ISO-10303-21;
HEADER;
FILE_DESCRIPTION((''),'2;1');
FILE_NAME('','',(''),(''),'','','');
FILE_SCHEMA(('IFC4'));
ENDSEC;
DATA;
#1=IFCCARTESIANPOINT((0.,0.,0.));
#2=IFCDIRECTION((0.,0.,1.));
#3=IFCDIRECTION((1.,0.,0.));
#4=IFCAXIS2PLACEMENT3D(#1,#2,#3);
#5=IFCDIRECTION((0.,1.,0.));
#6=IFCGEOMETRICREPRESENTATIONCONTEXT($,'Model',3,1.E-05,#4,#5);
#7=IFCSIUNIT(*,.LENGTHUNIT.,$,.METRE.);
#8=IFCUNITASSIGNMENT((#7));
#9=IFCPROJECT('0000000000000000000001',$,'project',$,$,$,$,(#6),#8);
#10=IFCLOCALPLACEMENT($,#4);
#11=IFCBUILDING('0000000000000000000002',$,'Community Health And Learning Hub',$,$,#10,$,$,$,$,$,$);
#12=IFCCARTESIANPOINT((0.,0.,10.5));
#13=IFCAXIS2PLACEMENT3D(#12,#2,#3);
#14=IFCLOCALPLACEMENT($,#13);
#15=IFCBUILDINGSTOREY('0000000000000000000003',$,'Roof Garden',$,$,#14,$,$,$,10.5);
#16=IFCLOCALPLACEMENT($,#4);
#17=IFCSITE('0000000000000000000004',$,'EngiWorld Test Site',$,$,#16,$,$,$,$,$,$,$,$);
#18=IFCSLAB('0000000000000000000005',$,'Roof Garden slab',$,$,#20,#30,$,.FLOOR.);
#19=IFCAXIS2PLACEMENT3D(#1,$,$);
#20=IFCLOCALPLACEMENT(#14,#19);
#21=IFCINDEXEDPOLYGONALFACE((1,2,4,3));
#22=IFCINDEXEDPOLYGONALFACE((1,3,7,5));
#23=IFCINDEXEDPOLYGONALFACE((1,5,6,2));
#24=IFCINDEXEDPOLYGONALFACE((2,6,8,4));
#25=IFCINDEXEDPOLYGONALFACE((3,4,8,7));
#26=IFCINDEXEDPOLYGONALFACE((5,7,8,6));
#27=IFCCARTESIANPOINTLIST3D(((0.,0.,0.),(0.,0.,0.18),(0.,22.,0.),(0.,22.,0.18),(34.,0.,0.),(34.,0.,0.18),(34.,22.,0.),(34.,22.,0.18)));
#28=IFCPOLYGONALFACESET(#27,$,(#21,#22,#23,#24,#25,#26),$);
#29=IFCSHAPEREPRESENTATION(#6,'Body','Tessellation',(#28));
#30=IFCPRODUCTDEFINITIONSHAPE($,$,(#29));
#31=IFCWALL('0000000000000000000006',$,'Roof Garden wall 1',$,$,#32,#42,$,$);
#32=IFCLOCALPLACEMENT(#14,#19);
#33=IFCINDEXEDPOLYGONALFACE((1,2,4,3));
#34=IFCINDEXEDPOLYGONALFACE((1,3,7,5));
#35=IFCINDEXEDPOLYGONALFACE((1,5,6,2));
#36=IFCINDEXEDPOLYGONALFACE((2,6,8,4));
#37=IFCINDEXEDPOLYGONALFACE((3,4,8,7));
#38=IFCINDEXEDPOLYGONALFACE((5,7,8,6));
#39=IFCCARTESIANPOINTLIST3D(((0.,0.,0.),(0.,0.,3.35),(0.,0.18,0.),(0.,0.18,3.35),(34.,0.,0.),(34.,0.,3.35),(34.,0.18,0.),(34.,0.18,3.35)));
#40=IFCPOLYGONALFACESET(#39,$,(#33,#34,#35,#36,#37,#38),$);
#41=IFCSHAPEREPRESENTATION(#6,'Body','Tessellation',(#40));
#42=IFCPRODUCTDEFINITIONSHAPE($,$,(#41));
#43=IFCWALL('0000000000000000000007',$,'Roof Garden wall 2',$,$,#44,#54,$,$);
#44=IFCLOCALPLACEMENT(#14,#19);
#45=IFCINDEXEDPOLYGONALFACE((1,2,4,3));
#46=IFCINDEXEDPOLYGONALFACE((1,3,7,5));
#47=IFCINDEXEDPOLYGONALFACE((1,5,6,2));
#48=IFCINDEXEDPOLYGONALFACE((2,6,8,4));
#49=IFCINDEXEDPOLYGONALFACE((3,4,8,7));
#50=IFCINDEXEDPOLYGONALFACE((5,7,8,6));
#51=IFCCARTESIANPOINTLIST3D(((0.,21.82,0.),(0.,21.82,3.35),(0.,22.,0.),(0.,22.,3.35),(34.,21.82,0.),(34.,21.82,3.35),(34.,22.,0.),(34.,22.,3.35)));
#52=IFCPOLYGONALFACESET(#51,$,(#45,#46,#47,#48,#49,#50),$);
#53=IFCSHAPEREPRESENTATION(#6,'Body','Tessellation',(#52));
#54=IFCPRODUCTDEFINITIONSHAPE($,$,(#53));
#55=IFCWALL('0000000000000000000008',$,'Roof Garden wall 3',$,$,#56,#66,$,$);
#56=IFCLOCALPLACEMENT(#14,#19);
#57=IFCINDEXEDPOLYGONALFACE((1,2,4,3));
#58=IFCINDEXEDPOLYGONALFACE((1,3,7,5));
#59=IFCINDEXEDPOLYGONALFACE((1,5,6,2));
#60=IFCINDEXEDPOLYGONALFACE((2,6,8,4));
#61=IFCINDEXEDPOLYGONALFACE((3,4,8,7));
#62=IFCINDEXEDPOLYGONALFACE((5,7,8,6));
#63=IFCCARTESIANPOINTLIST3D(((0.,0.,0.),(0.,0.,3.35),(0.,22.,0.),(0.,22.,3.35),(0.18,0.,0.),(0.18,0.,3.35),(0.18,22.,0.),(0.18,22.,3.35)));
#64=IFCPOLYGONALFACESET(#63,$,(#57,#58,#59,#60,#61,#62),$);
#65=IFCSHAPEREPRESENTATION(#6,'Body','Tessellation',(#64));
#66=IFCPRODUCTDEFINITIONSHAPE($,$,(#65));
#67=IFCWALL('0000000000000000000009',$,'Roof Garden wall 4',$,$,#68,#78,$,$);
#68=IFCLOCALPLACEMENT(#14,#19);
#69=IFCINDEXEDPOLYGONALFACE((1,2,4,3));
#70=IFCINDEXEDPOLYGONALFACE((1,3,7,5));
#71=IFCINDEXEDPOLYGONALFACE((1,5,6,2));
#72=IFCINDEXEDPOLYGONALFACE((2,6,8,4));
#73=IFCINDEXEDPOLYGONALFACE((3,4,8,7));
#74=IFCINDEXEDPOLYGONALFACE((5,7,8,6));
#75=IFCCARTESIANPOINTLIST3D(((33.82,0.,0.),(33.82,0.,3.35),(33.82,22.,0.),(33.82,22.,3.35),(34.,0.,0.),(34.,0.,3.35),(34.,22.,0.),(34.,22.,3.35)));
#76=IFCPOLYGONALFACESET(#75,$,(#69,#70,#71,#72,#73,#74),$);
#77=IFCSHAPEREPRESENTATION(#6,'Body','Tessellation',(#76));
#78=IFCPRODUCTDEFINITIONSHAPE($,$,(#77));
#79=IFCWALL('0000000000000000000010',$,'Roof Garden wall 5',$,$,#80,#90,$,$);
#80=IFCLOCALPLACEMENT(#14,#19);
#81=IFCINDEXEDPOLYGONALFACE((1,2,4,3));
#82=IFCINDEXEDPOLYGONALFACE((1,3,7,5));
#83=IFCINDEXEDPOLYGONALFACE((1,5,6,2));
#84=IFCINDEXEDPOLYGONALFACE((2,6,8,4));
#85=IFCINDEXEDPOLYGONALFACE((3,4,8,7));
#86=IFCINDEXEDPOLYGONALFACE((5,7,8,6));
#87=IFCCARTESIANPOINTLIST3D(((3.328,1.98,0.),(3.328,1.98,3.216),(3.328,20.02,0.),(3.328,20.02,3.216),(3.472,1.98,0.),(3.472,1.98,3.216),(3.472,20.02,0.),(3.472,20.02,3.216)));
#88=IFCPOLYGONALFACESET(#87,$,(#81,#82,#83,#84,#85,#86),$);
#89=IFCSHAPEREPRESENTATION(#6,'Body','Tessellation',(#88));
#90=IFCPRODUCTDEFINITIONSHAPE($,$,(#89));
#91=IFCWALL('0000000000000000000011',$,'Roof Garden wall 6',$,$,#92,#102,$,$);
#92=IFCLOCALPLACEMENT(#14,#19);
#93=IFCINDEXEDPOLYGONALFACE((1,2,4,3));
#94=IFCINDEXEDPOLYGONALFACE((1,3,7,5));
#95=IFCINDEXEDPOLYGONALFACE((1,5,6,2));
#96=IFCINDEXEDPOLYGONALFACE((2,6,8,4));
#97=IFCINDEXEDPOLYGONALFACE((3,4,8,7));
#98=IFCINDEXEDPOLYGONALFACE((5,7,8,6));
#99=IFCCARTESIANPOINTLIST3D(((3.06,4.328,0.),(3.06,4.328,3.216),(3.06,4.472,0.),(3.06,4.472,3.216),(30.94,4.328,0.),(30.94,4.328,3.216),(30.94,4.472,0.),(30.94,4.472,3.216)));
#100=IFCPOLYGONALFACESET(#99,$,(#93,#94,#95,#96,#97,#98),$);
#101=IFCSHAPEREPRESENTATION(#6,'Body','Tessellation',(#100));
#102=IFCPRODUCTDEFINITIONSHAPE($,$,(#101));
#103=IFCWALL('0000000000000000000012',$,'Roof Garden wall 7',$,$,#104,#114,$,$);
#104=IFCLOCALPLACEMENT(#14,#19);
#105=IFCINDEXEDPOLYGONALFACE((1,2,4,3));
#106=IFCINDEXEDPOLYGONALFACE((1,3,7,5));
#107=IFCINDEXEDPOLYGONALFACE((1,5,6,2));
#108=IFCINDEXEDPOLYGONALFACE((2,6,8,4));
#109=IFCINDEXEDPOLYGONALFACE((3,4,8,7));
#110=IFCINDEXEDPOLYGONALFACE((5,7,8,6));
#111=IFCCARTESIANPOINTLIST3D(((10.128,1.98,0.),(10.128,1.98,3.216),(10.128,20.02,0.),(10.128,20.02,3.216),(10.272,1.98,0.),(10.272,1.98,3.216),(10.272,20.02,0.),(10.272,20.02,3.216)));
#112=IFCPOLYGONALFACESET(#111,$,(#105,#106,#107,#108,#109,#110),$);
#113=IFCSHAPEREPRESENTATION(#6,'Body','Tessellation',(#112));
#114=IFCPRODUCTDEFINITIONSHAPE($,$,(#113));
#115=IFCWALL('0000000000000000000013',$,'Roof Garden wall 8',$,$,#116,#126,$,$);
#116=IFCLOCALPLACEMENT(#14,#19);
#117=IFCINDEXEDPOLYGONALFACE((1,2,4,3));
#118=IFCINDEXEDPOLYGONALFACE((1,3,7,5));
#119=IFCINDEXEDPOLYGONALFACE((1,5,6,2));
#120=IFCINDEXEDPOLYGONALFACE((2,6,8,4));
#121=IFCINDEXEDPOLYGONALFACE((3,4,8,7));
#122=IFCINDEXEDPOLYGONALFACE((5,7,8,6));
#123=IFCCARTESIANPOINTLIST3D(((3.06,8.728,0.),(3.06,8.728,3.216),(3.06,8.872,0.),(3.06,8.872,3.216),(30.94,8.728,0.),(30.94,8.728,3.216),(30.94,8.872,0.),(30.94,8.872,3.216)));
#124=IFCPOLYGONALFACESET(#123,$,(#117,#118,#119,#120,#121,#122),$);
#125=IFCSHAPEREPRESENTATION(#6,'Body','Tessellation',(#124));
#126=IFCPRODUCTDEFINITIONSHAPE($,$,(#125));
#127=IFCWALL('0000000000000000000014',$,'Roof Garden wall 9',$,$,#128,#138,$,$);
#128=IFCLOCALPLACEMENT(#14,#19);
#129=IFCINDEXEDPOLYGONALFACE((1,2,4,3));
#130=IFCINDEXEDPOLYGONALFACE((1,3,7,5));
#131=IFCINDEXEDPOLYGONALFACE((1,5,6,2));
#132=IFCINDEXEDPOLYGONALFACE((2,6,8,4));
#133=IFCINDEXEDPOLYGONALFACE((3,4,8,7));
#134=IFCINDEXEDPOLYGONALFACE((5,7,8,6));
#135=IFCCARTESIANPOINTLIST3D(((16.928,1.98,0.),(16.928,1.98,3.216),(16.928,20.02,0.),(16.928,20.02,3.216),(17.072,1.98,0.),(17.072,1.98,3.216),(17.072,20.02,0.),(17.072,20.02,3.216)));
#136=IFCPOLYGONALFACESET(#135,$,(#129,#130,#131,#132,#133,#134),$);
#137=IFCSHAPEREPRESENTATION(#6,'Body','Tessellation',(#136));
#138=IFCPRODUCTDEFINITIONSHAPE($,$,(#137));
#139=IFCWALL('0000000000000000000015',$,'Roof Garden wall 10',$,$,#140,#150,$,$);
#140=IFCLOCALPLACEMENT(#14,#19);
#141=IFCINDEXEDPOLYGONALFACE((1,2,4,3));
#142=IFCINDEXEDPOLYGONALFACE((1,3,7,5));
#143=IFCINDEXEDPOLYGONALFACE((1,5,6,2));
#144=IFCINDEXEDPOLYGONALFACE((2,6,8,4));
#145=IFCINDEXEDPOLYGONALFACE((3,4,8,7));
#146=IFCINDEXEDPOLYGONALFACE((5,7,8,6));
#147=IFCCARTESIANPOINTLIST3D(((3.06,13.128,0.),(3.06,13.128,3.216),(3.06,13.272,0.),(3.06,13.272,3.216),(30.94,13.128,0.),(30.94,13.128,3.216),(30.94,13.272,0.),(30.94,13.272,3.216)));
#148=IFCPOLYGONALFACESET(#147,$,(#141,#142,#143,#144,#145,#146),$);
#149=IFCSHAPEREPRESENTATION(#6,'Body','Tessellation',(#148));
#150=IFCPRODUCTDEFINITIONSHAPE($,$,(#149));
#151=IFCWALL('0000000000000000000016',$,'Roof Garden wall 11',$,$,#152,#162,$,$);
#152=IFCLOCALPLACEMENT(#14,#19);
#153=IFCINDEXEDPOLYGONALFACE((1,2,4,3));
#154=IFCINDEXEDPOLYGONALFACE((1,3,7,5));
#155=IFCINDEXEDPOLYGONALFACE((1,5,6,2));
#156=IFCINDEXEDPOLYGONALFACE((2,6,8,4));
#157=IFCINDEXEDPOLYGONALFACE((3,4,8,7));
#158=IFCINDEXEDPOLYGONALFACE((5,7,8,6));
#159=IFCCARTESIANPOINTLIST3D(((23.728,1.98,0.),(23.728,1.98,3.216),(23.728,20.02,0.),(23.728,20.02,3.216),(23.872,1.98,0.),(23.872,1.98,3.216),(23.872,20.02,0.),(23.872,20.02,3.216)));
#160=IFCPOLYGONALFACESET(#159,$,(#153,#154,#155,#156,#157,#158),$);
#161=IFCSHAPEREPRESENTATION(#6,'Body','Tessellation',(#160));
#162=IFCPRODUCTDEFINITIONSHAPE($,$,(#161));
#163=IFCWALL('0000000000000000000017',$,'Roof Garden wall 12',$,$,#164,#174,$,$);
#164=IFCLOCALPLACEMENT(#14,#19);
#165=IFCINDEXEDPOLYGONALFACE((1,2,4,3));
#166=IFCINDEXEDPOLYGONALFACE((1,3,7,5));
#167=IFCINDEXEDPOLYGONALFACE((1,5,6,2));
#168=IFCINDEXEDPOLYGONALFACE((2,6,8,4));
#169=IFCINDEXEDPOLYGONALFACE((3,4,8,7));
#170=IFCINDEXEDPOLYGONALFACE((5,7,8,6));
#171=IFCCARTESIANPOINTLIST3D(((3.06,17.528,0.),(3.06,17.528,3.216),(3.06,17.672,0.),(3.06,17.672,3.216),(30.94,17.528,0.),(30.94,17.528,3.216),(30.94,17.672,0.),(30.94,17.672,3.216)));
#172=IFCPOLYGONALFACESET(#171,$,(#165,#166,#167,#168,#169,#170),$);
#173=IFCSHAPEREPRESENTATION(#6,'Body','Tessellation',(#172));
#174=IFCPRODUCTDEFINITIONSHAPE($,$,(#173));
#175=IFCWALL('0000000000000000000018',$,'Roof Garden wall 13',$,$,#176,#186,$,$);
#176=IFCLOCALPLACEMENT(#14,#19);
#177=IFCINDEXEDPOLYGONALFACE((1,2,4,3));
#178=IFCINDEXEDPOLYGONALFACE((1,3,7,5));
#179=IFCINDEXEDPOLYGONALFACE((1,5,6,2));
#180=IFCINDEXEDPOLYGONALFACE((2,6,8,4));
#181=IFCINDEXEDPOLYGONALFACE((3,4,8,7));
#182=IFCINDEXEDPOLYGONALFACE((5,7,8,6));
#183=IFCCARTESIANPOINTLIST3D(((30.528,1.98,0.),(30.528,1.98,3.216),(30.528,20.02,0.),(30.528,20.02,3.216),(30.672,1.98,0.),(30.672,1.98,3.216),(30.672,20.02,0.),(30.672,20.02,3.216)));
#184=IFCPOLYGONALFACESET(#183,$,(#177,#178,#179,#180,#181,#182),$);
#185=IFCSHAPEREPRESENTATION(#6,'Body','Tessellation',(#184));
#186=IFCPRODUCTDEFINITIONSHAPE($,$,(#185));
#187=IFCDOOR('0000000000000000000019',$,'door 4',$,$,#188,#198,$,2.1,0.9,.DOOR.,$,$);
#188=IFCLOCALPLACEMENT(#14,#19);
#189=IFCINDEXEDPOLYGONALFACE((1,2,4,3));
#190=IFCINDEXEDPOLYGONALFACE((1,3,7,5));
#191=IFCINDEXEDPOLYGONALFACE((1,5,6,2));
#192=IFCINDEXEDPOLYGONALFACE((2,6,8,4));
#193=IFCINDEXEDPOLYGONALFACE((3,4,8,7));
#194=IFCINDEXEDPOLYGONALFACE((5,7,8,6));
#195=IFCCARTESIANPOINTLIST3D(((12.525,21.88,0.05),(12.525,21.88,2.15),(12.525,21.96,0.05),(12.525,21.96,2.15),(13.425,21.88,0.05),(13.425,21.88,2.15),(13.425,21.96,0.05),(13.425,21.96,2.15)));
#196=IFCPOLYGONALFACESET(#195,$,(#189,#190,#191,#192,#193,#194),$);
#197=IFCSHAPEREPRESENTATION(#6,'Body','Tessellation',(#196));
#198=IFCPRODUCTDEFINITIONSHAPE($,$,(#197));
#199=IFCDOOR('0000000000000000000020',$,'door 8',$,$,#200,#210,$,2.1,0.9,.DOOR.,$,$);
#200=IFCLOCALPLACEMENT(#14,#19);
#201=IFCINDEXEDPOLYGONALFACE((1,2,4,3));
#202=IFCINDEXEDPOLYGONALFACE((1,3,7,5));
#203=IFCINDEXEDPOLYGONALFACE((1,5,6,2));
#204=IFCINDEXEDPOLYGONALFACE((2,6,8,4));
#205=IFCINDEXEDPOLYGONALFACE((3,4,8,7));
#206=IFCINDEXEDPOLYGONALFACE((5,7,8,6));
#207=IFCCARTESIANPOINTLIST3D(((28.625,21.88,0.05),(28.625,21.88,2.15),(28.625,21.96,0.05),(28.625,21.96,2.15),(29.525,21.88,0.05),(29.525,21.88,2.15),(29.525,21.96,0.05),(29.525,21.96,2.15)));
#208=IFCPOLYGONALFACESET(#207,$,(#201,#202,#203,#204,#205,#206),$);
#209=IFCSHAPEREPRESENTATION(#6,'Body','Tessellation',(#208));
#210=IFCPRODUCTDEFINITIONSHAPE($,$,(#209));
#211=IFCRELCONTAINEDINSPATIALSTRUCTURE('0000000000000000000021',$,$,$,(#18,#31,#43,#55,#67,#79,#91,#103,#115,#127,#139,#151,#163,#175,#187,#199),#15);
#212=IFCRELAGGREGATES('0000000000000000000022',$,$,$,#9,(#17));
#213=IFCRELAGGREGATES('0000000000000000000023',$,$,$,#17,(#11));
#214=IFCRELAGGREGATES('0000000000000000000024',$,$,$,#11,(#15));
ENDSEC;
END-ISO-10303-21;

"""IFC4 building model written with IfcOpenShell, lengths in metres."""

from ifc_helpers import new_model, si_unit, direction, frame, origin_with_axes, origin_2d_with_axis, place, context, project, spatial, rectangle, extrude, element, save


model = new_model("IFC4")

# Units and contexts
model_context = context("Model", 3, precision=1e-05, world=origin_with_axes(), true_north=direction((0.0, 1.0, 0.0)))
ifc_project = project(units=[si_unit("LENGTHUNIT", "METRE")], contexts=[model_context])

# Site, building, storey
site_placement = place(None, origin_with_axes())
site = spatial("IfcSite", under=ifc_project, at=site_placement, Name="EngiWorld Test Site")
building_placement = place(None, origin_with_axes())
building = spatial("IfcBuilding", under=site, at=building_placement, Name="Community Health And Learning Hub")
storey_placement = place(None, frame((0.0, 0.0, 10.5), z_axis=(0.0, 0.0, 1.0), x_axis=(1.0, 0.0, 0.0)))
storey = spatial("IfcBuildingStorey", under=building, at=storey_placement, Name="Roof Garden", Elevation=10.5)

# Slab
slab_placement = place(None, frame((17.0, 11.0, 10.5), z_axis=(0.0, 0.0, 1.0), x_axis=(1.0, 0.0, 0.0)))
element("IfcSlab", 1, at=slab_placement, inside=storey, Name="Roof Garden slab", PredefinedType="FLOOR", context=model_context, shape_type="SweptSolid", body=[
    extrude(rectangle(XDim=34.0, YDim=22.0, at=origin_2d_with_axis()), origin_with_axes(), (0.0, 0.0, 1.0), 0.18),
])

# Walls
for number, where, z_axis, x_axis, name in (
    (2, (17.0, 0.09, 10.5), (0.0, 0.0, 1.0), (1.0, 0.0, 0.0), "Roof Garden wall 1"),
    (3, (17.0, 21.91, 10.5), (0.0, 0.0, 1.0), (1.0, 0.0, 0.0), "Roof Garden wall 2"),
):
    element("IfcWall", number, at=place(None, frame(where, z_axis=z_axis, x_axis=x_axis)), inside=storey, Name=name, context=model_context, shape_type="SweptSolid", body=[
        extrude(rectangle(XDim=34.0, YDim=0.18, at=origin_2d_with_axis()), origin_with_axes(), (0.0, 0.0, 1.0), 3.35),
    ])
for number, where, z_axis, x_axis, name in (
    (4, (0.09, 11.0, 10.5), (0.0, 0.0, 1.0), (1.0, 0.0, 0.0), "Roof Garden wall 3"),
    (5, (33.91, 11.0, 10.5), (0.0, 0.0, 1.0), (1.0, 0.0, 0.0), "Roof Garden wall 4"),
):
    element("IfcWall", number, at=place(None, frame(where, z_axis=z_axis, x_axis=x_axis)), inside=storey, Name=name, context=model_context, shape_type="SweptSolid", body=[
        extrude(rectangle(XDim=0.18, YDim=22.0, at=origin_2d_with_axis()), origin_with_axes(), (0.0, 0.0, 1.0), 3.35),
    ])
wall_1_placement = place(None, frame((3.4, 11.0, 10.5), z_axis=(0.0, 0.0, 1.0), x_axis=(1.0, 0.0, 0.0)))
element("IfcWall", 6, at=wall_1_placement, inside=storey, Name="Roof Garden wall 5", context=model_context, shape_type="SweptSolid", body=[
    extrude(rectangle(XDim=0.144, YDim=18.04, at=origin_2d_with_axis()), origin_with_axes(), (0.0, 0.0, 1.0), 3.216),
])
wall_2_placement = place(None, frame((17.0, 4.4, 10.5), z_axis=(0.0, 0.0, 1.0), x_axis=(1.0, 0.0, 0.0)))
element("IfcWall", 7, at=wall_2_placement, inside=storey, Name="Roof Garden wall 6", context=model_context, shape_type="SweptSolid", body=[
    extrude(rectangle(XDim=27.88, YDim=0.144, at=origin_2d_with_axis()), origin_with_axes(), (0.0, 0.0, 1.0), 3.216),
])
wall_3_placement = place(None, frame((10.2, 11.0, 10.5), z_axis=(0.0, 0.0, 1.0), x_axis=(1.0, 0.0, 0.0)))
element("IfcWall", 8, at=wall_3_placement, inside=storey, Name="Roof Garden wall 7", context=model_context, shape_type="SweptSolid", body=[
    extrude(rectangle(XDim=0.144, YDim=18.04, at=origin_2d_with_axis()), origin_with_axes(), (0.0, 0.0, 1.0), 3.216),
])
wall_4_placement = place(None, frame((17.0, 8.8, 10.5), z_axis=(0.0, 0.0, 1.0), x_axis=(1.0, 0.0, 0.0)))
element("IfcWall", 9, at=wall_4_placement, inside=storey, Name="Roof Garden wall 8", context=model_context, shape_type="SweptSolid", body=[
    extrude(rectangle(XDim=27.88, YDim=0.144, at=origin_2d_with_axis()), origin_with_axes(), (0.0, 0.0, 1.0), 3.216),
])
wall_5_placement = place(None, frame((17.0, 11.0, 10.5), z_axis=(0.0, 0.0, 1.0), x_axis=(1.0, 0.0, 0.0)))
element("IfcWall", 10, at=wall_5_placement, inside=storey, Name="Roof Garden wall 9", context=model_context, shape_type="SweptSolid", body=[
    extrude(rectangle(XDim=0.144, YDim=18.04, at=origin_2d_with_axis()), origin_with_axes(), (0.0, 0.0, 1.0), 3.216),
])
wall_6_placement = place(None, frame((17.0, 13.2, 10.5), z_axis=(0.0, 0.0, 1.0), x_axis=(1.0, 0.0, 0.0)))
element("IfcWall", 11, at=wall_6_placement, inside=storey, Name="Roof Garden wall 10", context=model_context, shape_type="SweptSolid", body=[
    extrude(rectangle(XDim=27.88, YDim=0.144, at=origin_2d_with_axis()), origin_with_axes(), (0.0, 0.0, 1.0), 3.216),
])
wall_7_placement = place(None, frame((23.8, 11.0, 10.5), z_axis=(0.0, 0.0, 1.0), x_axis=(1.0, 0.0, 0.0)))
element("IfcWall", 12, at=wall_7_placement, inside=storey, Name="Roof Garden wall 11", context=model_context, shape_type="SweptSolid", body=[
    extrude(rectangle(XDim=0.144, YDim=18.04, at=origin_2d_with_axis()), origin_with_axes(), (0.0, 0.0, 1.0), 3.216),
])
wall_8_placement = place(None, frame((17.0, 17.6, 10.5), z_axis=(0.0, 0.0, 1.0), x_axis=(1.0, 0.0, 0.0)))
element("IfcWall", 13, at=wall_8_placement, inside=storey, Name="Roof Garden wall 12", context=model_context, shape_type="SweptSolid", body=[
    extrude(rectangle(XDim=27.88, YDim=0.144, at=origin_2d_with_axis()), origin_with_axes(), (0.0, 0.0, 1.0), 3.216),
])
wall_9_placement = place(None, frame((30.6, 11.0, 10.5), z_axis=(0.0, 0.0, 1.0), x_axis=(1.0, 0.0, 0.0)))
element("IfcWall", 14, at=wall_9_placement, inside=storey, Name="Roof Garden wall 13", context=model_context, shape_type="SweptSolid", body=[
    extrude(rectangle(XDim=0.144, YDim=18.04, at=origin_2d_with_axis()), origin_with_axes(), (0.0, 0.0, 1.0), 3.216),
])

# Doors
for number, where, z_axis, x_axis, name in (
    (15, (12.975, 21.92, 10.55), (0.0, 0.0, 1.0), (1.0, 0.0, 0.0), "door 4"),
    (16, (29.075, 21.92, 10.55), (0.0, 0.0, 1.0), (1.0, 0.0, 0.0), "door 8"),
):
    element("IfcDoor", number, at=place(None, frame(where, z_axis=z_axis, x_axis=x_axis)), inside=storey, Name=name, OverallHeight=2.1, OverallWidth=0.9, PredefinedType="DOOR", context=model_context, shape_type="SweptSolid", body=[
        extrude(rectangle(XDim=0.9, YDim=0.08, at=origin_2d_with_axis()), origin_with_axes(), (0.0, 0.0, 1.0), 2.1),
    ])

save(model, "model.ifc")
